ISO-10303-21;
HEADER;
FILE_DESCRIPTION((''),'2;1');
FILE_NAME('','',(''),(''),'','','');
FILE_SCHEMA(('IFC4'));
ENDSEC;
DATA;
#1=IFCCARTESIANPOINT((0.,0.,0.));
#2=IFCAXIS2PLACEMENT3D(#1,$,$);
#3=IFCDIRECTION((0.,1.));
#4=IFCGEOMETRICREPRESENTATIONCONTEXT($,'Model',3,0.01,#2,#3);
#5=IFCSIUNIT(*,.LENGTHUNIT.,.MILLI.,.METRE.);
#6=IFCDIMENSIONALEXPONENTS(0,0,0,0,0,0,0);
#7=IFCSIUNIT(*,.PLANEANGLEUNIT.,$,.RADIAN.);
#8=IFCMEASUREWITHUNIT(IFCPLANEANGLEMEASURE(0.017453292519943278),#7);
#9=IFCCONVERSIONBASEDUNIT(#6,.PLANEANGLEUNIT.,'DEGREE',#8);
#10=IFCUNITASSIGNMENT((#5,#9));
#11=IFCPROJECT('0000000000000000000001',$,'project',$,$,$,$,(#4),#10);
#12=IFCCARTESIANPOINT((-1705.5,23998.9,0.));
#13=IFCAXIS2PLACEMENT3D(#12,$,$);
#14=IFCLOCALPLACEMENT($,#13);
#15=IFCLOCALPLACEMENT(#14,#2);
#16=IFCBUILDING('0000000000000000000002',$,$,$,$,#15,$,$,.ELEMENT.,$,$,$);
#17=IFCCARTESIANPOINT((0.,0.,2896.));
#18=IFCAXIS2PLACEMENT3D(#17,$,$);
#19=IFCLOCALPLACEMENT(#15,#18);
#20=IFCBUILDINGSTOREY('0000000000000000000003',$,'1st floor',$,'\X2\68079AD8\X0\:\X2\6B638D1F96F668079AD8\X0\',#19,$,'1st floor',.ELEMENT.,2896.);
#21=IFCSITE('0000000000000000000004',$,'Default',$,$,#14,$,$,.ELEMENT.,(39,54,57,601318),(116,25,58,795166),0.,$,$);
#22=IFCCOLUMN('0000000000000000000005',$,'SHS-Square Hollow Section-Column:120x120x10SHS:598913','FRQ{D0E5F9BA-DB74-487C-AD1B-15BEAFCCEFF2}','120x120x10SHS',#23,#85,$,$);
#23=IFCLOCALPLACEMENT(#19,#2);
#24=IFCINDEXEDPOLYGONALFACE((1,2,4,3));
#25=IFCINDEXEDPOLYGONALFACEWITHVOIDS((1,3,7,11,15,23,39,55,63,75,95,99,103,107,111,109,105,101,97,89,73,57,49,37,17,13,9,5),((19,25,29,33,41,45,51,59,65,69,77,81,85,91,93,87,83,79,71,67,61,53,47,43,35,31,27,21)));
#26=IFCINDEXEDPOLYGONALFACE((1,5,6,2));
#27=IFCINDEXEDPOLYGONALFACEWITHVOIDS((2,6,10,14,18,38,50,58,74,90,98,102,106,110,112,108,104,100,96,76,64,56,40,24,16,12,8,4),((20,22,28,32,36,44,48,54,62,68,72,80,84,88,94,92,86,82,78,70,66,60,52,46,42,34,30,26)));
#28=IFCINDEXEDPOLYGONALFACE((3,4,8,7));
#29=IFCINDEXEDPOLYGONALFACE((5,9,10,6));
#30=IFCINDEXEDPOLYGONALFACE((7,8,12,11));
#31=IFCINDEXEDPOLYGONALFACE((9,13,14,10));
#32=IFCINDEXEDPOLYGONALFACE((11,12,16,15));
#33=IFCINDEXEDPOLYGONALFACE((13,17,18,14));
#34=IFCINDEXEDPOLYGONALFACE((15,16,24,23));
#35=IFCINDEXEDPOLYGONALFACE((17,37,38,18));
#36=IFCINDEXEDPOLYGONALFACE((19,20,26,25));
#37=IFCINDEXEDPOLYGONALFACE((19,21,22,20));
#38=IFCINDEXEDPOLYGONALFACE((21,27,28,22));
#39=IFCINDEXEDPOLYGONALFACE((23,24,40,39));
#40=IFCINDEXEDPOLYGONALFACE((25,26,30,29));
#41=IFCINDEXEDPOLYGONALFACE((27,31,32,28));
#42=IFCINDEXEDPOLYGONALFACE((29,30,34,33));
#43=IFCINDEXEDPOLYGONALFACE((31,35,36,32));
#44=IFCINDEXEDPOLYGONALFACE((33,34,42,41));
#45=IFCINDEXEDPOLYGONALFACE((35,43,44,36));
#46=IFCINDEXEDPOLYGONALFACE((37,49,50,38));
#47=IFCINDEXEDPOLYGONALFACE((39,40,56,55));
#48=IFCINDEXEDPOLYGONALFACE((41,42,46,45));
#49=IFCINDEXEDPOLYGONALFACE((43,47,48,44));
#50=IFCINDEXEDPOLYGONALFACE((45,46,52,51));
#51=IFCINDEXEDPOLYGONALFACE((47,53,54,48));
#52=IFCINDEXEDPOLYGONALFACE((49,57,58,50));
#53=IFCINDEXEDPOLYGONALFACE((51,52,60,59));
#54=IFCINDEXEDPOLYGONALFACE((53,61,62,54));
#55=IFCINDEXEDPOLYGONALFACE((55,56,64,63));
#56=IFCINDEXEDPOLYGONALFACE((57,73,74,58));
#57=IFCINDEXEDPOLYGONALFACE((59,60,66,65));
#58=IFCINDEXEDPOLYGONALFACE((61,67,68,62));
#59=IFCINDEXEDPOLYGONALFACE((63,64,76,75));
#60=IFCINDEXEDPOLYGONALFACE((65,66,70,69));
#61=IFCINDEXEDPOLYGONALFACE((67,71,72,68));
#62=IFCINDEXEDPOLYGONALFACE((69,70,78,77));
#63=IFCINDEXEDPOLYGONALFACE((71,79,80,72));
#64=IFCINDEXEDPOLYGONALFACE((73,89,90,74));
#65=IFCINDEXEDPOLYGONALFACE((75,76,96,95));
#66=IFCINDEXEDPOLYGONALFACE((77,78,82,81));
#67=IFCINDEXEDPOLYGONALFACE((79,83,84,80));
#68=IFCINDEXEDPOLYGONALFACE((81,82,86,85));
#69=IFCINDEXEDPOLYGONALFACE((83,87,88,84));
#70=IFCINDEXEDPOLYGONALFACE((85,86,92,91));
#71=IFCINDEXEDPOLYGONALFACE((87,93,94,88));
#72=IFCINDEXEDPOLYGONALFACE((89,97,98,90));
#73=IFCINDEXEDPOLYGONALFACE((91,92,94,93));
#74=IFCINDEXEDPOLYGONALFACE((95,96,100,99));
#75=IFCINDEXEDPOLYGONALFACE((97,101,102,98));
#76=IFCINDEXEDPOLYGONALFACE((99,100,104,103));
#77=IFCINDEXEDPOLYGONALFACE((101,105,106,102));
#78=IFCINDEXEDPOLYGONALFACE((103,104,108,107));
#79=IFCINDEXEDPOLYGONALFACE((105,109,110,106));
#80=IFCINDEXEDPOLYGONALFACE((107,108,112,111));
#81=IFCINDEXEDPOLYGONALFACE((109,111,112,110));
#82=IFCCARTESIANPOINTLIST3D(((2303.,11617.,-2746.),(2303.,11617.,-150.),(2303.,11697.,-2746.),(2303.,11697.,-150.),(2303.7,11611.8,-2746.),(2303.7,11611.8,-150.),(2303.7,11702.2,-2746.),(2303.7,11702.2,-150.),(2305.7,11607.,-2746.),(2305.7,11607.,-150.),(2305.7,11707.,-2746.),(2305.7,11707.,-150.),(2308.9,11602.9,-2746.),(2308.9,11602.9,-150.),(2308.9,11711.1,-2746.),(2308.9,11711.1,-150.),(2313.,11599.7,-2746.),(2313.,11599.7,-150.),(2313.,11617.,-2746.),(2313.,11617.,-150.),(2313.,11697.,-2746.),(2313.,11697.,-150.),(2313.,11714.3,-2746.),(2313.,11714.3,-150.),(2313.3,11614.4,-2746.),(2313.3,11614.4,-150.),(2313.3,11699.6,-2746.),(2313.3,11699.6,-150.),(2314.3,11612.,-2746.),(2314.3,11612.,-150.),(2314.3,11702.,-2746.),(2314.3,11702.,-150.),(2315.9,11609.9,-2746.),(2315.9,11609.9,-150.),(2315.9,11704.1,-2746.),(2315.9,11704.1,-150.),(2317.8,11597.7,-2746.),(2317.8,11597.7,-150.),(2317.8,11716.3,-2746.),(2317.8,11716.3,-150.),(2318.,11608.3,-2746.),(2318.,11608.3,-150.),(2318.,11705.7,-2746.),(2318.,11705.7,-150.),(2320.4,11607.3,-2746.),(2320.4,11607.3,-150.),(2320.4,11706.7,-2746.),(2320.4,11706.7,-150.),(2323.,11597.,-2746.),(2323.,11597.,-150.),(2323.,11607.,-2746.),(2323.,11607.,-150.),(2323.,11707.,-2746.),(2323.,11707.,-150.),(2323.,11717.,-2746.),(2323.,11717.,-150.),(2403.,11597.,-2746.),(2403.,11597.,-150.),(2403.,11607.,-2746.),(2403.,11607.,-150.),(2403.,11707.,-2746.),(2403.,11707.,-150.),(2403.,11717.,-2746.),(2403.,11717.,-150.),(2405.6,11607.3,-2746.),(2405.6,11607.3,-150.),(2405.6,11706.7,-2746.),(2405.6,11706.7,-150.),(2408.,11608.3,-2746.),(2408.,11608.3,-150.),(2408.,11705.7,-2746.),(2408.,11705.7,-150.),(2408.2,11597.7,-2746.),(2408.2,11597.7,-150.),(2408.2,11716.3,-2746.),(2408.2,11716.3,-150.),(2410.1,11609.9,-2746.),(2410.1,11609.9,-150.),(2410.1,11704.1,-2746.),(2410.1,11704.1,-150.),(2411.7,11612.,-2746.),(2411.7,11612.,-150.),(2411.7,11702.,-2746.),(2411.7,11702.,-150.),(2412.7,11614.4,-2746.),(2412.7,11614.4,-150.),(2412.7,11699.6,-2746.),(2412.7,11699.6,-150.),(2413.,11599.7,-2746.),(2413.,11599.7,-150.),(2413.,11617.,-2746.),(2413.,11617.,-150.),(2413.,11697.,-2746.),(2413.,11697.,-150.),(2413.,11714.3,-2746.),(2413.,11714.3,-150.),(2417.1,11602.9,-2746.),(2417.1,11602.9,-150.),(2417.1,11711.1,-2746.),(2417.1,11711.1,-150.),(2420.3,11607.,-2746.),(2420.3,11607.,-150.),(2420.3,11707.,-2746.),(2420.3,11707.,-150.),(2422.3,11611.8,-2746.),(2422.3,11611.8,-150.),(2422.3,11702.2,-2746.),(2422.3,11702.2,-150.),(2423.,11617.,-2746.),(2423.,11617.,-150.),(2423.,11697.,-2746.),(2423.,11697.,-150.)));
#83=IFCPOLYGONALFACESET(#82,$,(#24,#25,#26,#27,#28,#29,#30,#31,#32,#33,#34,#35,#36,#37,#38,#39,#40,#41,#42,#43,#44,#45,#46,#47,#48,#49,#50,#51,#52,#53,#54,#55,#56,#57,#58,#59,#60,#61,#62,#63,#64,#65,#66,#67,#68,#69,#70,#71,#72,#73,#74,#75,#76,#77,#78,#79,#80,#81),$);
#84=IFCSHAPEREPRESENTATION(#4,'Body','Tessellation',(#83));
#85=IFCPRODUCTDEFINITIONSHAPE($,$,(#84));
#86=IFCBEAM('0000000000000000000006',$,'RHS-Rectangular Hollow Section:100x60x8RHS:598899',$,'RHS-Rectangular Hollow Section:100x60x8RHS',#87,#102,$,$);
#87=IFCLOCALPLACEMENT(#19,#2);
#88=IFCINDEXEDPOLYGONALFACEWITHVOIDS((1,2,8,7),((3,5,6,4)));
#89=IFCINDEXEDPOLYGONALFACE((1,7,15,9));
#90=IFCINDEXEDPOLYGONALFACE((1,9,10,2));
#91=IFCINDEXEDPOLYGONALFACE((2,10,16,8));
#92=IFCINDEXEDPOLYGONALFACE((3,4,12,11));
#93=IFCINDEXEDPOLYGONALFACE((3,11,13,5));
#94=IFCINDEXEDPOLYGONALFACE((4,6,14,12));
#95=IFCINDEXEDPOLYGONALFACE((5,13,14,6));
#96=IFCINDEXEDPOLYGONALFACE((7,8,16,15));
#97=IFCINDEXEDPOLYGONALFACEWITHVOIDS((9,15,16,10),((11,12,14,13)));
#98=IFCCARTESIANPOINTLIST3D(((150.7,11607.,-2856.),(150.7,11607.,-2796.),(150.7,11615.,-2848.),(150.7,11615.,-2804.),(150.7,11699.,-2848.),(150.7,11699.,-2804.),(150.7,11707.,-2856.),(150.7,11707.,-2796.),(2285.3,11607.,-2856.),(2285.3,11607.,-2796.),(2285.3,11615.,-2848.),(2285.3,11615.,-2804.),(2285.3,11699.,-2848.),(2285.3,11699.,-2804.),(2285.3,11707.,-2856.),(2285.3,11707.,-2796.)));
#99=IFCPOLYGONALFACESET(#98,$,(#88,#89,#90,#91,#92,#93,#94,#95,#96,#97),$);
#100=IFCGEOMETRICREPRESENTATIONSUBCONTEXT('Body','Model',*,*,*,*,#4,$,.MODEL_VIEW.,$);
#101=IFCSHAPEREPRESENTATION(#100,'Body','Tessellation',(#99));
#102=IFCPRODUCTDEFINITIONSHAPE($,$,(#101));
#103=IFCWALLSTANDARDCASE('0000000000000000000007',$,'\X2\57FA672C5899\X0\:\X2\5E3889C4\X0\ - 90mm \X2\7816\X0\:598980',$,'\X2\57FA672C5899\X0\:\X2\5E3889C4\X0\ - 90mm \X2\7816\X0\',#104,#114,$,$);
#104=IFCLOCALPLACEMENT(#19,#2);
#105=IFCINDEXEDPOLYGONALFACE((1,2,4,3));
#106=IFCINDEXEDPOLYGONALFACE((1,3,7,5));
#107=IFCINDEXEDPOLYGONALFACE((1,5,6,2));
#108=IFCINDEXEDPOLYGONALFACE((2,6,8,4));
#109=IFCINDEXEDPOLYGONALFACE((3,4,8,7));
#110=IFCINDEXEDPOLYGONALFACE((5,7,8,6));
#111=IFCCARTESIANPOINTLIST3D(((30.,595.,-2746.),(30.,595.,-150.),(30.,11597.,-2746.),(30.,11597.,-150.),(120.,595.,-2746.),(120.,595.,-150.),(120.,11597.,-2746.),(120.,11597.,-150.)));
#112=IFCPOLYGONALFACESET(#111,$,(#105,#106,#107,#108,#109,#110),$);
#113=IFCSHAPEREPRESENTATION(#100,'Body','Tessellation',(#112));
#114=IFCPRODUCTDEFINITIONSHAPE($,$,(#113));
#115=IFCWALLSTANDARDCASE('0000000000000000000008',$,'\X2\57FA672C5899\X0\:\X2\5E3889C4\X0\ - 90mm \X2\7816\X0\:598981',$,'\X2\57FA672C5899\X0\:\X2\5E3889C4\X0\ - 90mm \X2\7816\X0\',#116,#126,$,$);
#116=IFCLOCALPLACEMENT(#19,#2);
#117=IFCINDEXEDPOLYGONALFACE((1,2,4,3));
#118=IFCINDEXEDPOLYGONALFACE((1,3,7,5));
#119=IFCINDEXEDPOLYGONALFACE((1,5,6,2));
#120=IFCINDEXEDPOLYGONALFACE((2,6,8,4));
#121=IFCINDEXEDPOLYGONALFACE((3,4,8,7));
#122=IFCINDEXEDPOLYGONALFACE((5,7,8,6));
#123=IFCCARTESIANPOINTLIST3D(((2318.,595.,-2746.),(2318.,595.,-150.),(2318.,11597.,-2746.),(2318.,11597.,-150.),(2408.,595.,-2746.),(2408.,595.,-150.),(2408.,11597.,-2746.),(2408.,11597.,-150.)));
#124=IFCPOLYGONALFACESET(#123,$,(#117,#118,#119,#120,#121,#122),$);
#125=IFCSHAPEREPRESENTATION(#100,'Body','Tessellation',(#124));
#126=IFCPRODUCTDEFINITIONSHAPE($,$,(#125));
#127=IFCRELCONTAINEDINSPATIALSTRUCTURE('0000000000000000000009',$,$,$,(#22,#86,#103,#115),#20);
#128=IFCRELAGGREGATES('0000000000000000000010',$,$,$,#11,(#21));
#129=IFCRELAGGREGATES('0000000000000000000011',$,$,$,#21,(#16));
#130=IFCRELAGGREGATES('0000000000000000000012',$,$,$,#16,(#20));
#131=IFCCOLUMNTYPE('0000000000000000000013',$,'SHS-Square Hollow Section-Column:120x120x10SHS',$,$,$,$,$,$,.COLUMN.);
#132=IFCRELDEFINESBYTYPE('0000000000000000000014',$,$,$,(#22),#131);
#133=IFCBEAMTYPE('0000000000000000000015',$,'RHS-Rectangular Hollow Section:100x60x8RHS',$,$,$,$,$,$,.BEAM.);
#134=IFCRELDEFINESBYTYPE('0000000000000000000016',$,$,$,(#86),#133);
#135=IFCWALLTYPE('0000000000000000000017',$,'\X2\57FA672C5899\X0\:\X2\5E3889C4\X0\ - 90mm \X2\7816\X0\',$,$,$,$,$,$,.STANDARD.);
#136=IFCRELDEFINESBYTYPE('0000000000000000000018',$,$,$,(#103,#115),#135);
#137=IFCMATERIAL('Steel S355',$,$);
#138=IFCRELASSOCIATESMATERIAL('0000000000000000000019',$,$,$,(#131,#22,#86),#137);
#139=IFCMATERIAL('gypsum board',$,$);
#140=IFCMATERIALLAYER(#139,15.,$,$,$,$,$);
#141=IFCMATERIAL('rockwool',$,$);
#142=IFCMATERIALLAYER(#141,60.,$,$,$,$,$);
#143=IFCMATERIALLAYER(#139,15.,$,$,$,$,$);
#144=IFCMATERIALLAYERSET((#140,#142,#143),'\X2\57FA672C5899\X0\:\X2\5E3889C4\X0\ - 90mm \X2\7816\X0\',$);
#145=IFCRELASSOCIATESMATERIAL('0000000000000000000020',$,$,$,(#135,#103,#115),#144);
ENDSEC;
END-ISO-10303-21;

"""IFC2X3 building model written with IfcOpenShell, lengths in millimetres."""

from ifc_helpers import new_model, entity, si_unit, converted_unit, direction, frame, frame_2d, origin, origin_2d, place, context, subcontext, project, spatial, rectangle, hollow_rectangle, extrude, boolean, clip, halfspace, material, layer, layer_set, layer_usage, type_object, element, save


model = new_model("IFC2X3")

# Units and contexts
model_context = context("Model", 3, precision=0.01, world=origin(), true_north=direction((0.0, 1.0)))
body_context = subcontext(model_context, "Body", "Model", "MODEL_VIEW")
ifc_project = project(units=[si_unit("LENGTHUNIT", "METRE", prefix="MILLI"), converted_unit("PLANEANGLEUNIT", "DEGREE", entity("IfcPlaneAngleMeasure", 0.017453292519943278), si_unit("PLANEANGLEUNIT", "RADIAN"), dimensions=[0, 0, 0, 0, 0, 0, 0])], contexts=[model_context])

# Site, building, storey
site_placement = place(None, frame((-1705.5, 23998.9, 0.0)))
site = spatial("IfcSite", under=ifc_project, at=site_placement, Name="Default", CompositionType="ELEMENT", RefLatitude=(39, 54, 57, 601318), RefLongitude=(116, 25, 58, 795166), RefElevation=0.0)
building_placement = place(site_placement, origin())
building = spatial("IfcBuilding", under=site, at=building_placement, CompositionType="ELEMENT")
storey_placement = place(building_placement, frame((0.0, 0.0, 2896.0)))
storey = spatial("IfcBuildingStorey", under=building, at=storey_placement, Name="1st floor", ObjectType="标高:正负零标高", LongName="1st floor", CompositionType="ELEMENT", Elevation=2896.0)

# Shared definitions
ifc_material_1 = material(Name="Steel S355")

# Column
column_type_1 = type_object("IfcColumnType", Name="SHS-Square Hollow Section-Column:120x120x10SHS", PredefinedType="COLUMN", material=ifc_material_1)
column_1_placement = place(storey_placement, frame((2363.0, 11657.0, -65.1), z_axis=(0.0, 0.0, 1.0), x_axis=(0.0, -1.0, 0.0)))
element("IfcColumn", 1, at=column_1_placement, inside=storey, type_object=column_type_1, material=ifc_material_1, Name="SHS-Square Hollow Section-Column:120x120x10SHS:598913", Description="FRQ{D0E5F9BA-DB74-487C-AD1B-15BEAFCCEFF2}", ObjectType="120x120x10SHS", context=model_context, shape_type="Clipping", body=[
    clip(clip(extrude(hollow_rectangle(XDim=120.0, YDim=120.0, WallThickness=10.0, InnerFilletRadius=10.0, OuterFilletRadius=20.0, at=origin_2d()), origin(), (0.0, 0.0, -1.0), 2765.7), halfspace(frame((11657.0, -2363.0, -84.9), z_axis=(0.0, 0.0, -1.0), x_axis=(0.0, -1.0, 0.0)), True)), halfspace(frame((11657.0, -2363.0, -2680.9), z_axis=(0.0, 0.0, 1.0), x_axis=(0.0, 1.0, 0.0)), True)),
])

# Beam
beam_type_1 = type_object("IfcBeamType", Name="RHS-Rectangular Hollow Section:100x60x8RHS", PredefinedType="BEAM")
beam_1_placement = place(storey_placement, frame((150.7, 11707.0, -2826.0)))
element("IfcBeam", 2, at=beam_1_placement, inside=storey, type_object=beam_type_1, material=ifc_material_1, Name="RHS-Rectangular Hollow Section:100x60x8RHS:598899", ObjectType="RHS-Rectangular Hollow Section:100x60x8RHS", context=body_context, shape_type="SweptSolid", body=[
    boolean("DIFFERENCE", extrude(rectangle(XDim=60.0, YDim=100.0, at=frame_2d((0.0, 0.0), x_axis=(1.0, 0.0))), frame((0.0, -50.0, 0.0), z_axis=(1.0, 0.0, 0.0), x_axis=(0.0, 0.0, -1.0)), (0.0, 0.0, 1.0), 2134.6), extrude(rectangle(XDim=44.0, YDim=84.0, at=frame_2d((0.0, 0.0), x_axis=(0.0, 1.0))), frame((2134.6, -50.0, 0.0), z_axis=(-1.0, 0.0, 0.0), x_axis=(0.0, 1.0, 0.0)), (0.0, 0.0, 1.0), 2134.6)),
])

# Walls
ifc_material_2 = material(Name="gypsum board")
ifc_layer_1 = layer(ifc_material_2, 15.0)
ifc_material_3 = material(Name="rockwool")
ifc_layer_2 = layer(ifc_material_3, 60.0)
ifc_layer_3 = layer(ifc_material_2, 15.0)
ifc_layer_set = layer_set([ifc_layer_1, ifc_layer_2, ifc_layer_3], Name="基本墙:常规 - 90mm 砖")
ifc_layer_usage_1 = layer_usage(ifc_layer_set, "AXIS2", "NEGATIVE", 45.0)
wall_type = type_object("IfcWallType", Name="基本墙:常规 - 90mm 砖", PredefinedType="STANDARD", material=ifc_layer_set)
wall_1_placement = place(storey_placement, frame((75.0, 11597.0, -2746.0), z_axis=(0.0, 0.0, 1.0), x_axis=(0.0, -1.0, 0.0)))
element("IfcWallStandardCase", 3, at=wall_1_placement, inside=storey, type_object=wall_type, material=ifc_layer_usage_1, Name="基本墙:常规 - 90mm 砖:598980", ObjectType="基本墙:常规 - 90mm 砖", context=body_context, shape_type="SweptSolid", body=[
    extrude(rectangle(XDim=11002.0, YDim=90.0, at=frame_2d((5501.0, 0.0), x_axis=(-1.0, 0.0))), origin(), (0.0, 0.0, 1.0), 2596.0),
])
ifc_layer_usage_2 = layer_usage(ifc_layer_set, "AXIS2", "NEGATIVE", 45.0)
wall_2_placement = place(storey_placement, frame((2363.0, 11597.0, -2746.0), z_axis=(0.0, 0.0, 1.0), x_axis=(0.0, -1.0, 0.0)))
element("IfcWallStandardCase", 4, at=wall_2_placement, inside=storey, type_object=wall_type, material=ifc_layer_usage_2, Name="基本墙:常规 - 90mm 砖:598981", ObjectType="基本墙:常规 - 90mm 砖", context=body_context, shape_type="SweptSolid", body=[
    extrude(rectangle(XDim=11002.0, YDim=90.0, at=frame_2d((5501.0, 0.0), x_axis=(-1.0, 0.0))), origin(), (0.0, 0.0, 1.0), 2596.0),
])

save(model, "model.ifc")
